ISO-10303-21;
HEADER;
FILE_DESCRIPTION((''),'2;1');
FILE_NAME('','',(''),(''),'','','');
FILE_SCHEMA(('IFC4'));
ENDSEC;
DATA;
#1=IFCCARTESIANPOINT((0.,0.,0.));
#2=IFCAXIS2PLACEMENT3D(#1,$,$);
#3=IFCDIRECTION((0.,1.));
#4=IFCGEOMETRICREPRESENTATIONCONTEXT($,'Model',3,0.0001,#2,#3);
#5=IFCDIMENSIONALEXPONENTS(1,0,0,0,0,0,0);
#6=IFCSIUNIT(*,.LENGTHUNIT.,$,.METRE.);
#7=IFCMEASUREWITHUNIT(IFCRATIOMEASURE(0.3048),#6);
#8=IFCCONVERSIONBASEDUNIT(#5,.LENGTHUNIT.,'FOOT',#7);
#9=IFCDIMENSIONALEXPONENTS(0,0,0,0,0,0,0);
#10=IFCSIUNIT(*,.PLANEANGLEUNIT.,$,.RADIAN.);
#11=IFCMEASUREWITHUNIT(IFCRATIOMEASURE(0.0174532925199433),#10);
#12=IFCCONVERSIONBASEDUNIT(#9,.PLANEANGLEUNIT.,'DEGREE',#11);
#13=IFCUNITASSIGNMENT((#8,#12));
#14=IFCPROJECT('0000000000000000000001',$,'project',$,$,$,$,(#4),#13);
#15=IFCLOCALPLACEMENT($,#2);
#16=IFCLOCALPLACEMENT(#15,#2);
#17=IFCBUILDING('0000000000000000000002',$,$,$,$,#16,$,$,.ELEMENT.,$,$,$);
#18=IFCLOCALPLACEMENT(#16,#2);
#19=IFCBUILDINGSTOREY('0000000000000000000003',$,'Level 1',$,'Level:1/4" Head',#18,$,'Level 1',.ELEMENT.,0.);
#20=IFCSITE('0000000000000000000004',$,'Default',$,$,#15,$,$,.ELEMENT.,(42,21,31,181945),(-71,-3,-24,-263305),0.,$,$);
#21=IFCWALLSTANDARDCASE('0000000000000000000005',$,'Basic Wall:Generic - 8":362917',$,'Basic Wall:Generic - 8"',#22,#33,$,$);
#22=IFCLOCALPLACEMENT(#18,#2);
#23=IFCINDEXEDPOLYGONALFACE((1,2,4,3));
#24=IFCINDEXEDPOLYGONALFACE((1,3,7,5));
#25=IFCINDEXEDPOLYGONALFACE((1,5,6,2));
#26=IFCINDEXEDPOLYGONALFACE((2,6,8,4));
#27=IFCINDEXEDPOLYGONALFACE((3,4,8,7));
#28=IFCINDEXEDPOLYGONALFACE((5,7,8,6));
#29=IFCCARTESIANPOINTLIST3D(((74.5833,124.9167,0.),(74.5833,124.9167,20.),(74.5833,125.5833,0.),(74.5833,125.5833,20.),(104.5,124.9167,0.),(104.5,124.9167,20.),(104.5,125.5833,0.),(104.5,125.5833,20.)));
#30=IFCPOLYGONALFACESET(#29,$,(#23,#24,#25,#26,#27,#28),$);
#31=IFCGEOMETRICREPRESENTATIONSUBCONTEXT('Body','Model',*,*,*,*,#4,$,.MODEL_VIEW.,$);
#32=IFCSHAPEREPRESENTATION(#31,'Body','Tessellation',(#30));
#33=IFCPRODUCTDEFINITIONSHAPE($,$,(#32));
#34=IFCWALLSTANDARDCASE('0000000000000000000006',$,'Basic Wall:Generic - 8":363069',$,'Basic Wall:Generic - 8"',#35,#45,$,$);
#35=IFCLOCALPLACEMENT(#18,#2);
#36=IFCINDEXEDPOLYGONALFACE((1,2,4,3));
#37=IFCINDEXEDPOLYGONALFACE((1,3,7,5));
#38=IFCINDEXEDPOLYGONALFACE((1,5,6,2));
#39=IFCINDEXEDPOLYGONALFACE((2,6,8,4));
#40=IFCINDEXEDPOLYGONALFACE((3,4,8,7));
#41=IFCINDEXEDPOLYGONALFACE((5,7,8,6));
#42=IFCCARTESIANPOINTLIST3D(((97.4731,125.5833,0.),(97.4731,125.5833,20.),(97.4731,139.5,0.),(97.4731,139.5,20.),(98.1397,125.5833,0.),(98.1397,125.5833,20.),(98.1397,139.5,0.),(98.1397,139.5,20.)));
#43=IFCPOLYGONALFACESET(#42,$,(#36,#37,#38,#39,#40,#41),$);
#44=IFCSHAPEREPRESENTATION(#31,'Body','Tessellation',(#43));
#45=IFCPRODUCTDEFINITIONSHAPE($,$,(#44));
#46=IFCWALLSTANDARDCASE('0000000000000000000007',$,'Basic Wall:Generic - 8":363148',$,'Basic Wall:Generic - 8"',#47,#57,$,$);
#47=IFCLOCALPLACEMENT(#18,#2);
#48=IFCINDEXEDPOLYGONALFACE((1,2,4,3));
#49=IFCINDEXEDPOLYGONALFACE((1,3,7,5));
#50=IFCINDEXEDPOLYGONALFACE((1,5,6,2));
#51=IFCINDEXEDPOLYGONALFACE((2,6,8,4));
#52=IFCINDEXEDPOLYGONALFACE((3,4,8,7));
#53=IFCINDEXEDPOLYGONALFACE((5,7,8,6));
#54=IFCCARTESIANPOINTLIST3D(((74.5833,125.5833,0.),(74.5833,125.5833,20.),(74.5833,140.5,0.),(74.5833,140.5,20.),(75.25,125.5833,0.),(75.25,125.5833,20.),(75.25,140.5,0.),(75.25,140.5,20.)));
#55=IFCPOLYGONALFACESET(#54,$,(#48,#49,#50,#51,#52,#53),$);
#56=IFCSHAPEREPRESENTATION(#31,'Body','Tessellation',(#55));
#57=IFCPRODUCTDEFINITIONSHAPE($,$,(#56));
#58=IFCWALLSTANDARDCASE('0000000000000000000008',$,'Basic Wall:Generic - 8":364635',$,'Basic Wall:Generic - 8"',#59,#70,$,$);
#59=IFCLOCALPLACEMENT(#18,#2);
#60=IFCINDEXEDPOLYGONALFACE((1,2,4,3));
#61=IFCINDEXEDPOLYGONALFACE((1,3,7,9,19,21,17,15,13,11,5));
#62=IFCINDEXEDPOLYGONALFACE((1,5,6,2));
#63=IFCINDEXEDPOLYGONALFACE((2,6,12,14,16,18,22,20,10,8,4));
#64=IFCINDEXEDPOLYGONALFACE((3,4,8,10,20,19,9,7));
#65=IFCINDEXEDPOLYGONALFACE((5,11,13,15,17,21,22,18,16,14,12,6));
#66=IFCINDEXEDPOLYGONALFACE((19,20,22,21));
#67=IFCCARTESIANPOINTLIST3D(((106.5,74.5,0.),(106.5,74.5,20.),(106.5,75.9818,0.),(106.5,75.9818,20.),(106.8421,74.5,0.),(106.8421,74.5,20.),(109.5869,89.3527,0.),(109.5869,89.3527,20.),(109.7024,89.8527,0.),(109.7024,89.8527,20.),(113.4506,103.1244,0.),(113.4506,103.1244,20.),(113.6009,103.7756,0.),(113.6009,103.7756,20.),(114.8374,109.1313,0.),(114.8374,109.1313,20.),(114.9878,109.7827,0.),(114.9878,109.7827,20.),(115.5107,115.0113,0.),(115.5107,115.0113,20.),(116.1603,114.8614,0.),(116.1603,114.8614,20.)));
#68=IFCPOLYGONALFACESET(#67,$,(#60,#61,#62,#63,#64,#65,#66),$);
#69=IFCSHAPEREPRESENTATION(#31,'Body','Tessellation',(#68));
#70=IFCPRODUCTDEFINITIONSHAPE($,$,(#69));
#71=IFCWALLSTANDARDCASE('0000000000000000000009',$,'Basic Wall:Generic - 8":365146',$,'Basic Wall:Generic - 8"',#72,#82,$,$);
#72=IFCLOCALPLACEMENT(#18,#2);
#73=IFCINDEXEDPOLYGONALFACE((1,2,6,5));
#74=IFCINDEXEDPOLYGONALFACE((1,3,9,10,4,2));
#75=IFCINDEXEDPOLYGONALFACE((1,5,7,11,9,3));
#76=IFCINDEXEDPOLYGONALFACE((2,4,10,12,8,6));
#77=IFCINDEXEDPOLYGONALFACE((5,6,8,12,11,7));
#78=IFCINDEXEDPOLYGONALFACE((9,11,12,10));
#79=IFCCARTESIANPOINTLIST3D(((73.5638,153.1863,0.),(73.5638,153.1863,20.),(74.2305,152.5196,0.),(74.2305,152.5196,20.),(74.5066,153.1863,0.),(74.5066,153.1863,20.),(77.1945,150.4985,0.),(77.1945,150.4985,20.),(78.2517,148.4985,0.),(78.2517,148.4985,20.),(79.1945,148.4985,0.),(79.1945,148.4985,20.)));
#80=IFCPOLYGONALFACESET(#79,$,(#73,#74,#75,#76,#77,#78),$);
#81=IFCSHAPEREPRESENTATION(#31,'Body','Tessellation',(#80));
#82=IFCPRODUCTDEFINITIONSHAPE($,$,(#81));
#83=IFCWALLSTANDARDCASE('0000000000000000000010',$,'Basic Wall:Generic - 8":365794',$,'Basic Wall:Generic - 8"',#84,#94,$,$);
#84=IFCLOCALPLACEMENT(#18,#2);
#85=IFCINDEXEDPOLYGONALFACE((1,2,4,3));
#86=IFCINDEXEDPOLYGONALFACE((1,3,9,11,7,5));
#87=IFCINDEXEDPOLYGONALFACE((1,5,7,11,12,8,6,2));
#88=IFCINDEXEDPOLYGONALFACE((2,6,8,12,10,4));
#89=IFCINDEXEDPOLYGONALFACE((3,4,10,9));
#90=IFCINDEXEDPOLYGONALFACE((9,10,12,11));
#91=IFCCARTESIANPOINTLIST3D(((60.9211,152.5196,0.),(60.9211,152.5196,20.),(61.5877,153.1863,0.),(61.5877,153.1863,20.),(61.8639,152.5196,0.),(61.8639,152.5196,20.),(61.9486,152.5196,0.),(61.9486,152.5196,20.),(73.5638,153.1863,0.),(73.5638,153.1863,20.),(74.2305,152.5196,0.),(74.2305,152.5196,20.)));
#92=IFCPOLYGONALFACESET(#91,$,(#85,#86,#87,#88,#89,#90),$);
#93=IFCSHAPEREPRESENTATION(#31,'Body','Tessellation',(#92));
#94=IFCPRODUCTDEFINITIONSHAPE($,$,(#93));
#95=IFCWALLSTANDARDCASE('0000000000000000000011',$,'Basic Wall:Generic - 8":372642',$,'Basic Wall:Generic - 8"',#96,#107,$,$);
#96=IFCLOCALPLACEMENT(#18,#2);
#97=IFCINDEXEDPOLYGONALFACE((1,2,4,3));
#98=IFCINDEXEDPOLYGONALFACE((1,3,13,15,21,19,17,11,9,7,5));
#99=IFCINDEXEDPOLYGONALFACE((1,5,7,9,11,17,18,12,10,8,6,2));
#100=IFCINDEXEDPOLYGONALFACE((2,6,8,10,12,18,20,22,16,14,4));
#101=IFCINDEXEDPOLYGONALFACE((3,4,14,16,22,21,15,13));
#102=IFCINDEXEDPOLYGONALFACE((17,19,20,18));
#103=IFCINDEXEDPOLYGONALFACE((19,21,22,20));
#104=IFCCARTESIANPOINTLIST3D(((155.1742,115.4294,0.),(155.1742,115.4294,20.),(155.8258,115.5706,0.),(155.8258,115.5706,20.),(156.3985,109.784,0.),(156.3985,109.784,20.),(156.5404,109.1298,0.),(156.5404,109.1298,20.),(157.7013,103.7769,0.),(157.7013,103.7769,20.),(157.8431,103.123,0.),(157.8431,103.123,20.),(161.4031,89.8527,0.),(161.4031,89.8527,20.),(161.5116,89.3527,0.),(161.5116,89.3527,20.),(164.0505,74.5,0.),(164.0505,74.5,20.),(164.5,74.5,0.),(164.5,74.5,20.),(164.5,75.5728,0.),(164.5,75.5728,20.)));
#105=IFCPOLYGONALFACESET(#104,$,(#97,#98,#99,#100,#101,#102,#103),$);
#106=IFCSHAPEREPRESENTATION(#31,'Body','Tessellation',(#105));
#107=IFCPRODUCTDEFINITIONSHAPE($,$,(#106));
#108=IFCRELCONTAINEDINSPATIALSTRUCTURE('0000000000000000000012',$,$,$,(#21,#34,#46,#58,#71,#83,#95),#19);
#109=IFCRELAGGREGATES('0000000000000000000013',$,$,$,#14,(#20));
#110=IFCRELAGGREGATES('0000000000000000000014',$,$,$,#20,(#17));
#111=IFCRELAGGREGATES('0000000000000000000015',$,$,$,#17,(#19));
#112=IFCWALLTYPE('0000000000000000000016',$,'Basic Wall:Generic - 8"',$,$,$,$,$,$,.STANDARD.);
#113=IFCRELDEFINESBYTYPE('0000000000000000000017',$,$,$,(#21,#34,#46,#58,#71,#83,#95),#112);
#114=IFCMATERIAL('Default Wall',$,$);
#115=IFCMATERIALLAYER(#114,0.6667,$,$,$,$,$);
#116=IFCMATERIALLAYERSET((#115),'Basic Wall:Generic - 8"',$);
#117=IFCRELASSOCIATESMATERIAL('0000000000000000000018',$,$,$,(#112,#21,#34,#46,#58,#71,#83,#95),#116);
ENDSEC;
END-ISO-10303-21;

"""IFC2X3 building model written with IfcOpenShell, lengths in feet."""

from ifc_helpers import new_model, entity, si_unit, converted_unit, direction, frame, frame_2d, origin, place, context, subcontext, project, spatial, polyline, rectangle, outline, extrude, material, layer, layer_set, layer_usage, type_object, element, save


model = new_model("IFC2X3")

# Units and contexts
model_context = context("Model", 3, precision=0.0001, world=origin(), true_north=direction((0.0, 1.0)))
body_context = subcontext(model_context, "Body", "Model", "MODEL_VIEW")
ifc_project = project(units=[converted_unit("LENGTHUNIT", "FOOT", entity("IfcRatioMeasure", 0.3048), si_unit("LENGTHUNIT", "METRE"), dimensions=[1, 0, 0, 0, 0, 0, 0]), converted_unit("PLANEANGLEUNIT", "DEGREE", entity("IfcRatioMeasure", 0.0174532925199433), si_unit("PLANEANGLEUNIT", "RADIAN"), dimensions=[0, 0, 0, 0, 0, 0, 0])], contexts=[model_context])

# Site, building, storey
site_placement = place(None, origin())
site = spatial("IfcSite", under=ifc_project, at=site_placement, Name="Default", CompositionType="ELEMENT", RefLatitude=(42, 21, 31, 181945), RefLongitude=(-71, -3, -24, -263305), RefElevation=0.0)
building_placement = place(site_placement, origin())
building = spatial("IfcBuilding", under=site, at=building_placement, CompositionType="ELEMENT")
storey_placement = place(building_placement, origin())
storey = spatial("IfcBuildingStorey", under=building, at=storey_placement, Name="Level 1", ObjectType="Level:1/4\" Head", LongName="Level 1", CompositionType="ELEMENT", Elevation=0.0)

# Walls
ifc_material = material(Name="Default Wall")
ifc_layer_1 = layer(ifc_material, 0.6667)
ifc_layer_set_1 = layer_set([ifc_layer_1], Name="Basic Wall:Generic - 8\"")
ifc_layer_usage_1 = layer_usage(ifc_layer_set_1, "AXIS2", "NEGATIVE", 0.3333)
wall_type_1 = type_object("IfcWallType", Name="Basic Wall:Generic - 8\"", PredefinedType="STANDARD", material=ifc_layer_set_1)
wall_1_placement = place(storey_placement, frame((74.5833, 125.25, 0.0)))
element("IfcWallStandardCase", 1, at=wall_1_placement, inside=storey, type_object=wall_type_1, material=ifc_layer_usage_1, Name="Basic Wall:Generic - 8\":362917", ObjectType="Basic Wall:Generic - 8\"", context=body_context, shape_type="SweptSolid", body=[
    extrude(rectangle(XDim=29.9167, YDim=0.6667, at=frame_2d((14.9583, 0.0), x_axis=(-1.0, 0.0))), origin(), (0.0, 0.0, 1.0), 20.0),
])
ifc_layer_usage_2 = layer_usage(ifc_layer_set_1, "AXIS2", "NEGATIVE", 0.3333)
wall_2_placement = place(storey_placement, frame((97.8064, 139.5, 0.0), z_axis=(0.0, 0.0, 1.0), x_axis=(0.0, -1.0, 0.0)))
element("IfcWallStandardCase", 2, at=wall_2_placement, inside=storey, type_object=wall_type_1, material=ifc_layer_usage_2, Name="Basic Wall:Generic - 8\":363069", ObjectType="Basic Wall:Generic - 8\"", context=body_context, shape_type="SweptSolid", body=[
    extrude(rectangle(XDim=13.9167, YDim=0.6667, at=frame_2d((6.9583, 0.0), x_axis=(-1.0, 0.0))), origin(), (0.0, 0.0, 1.0), 20.0),
])
ifc_layer_usage_3 = layer_usage(ifc_layer_set_1, "AXIS2", "NEGATIVE", 0.3333)
wall_3_placement = place(storey_placement, frame((74.9167, 140.5, 0.0), z_axis=(0.0, 0.0, 1.0), x_axis=(0.0, -1.0, 0.0)))
element("IfcWallStandardCase", 3, at=wall_3_placement, inside=storey, type_object=wall_type_1, material=ifc_layer_usage_3, Name="Basic Wall:Generic - 8\":363148", ObjectType="Basic Wall:Generic - 8\"", context=body_context, shape_type="SweptSolid", body=[
    extrude(rectangle(XDim=14.9167, YDim=0.6667, at=frame_2d((7.4583, 0.0), x_axis=(-1.0, 0.0))), origin(), (0.0, 0.0, 1.0), 20.0),
])
ifc_layer_usage_4 = layer_usage(ifc_layer_set_1, "AXIS2", "NEGATIVE", 0.3333)
wall_4_placement = place(storey_placement, frame((106.5173, 74.575, 0.0), z_axis=(0.0, 0.0, 1.0), x_axis=(0.224951, 0.97437, 0.0)))
element("IfcWallStandardCase", 4, at=wall_4_placement, inside=storey, type_object=wall_type_1, material=ifc_layer_usage_4, Name="Basic Wall:Generic - 8\":364635", ObjectType="Basic Wall:Generic - 8\"", context=body_context, shape_type="SweptSolid", body=[
    extrude(outline(polyline([(41.423, -0.3333), (41.423, 0.3333), (15.6027, 0.3333), (15.0895, 0.3333), (1.3669, 0.3333), (-0.077, 0.0), (0.0, -0.3333), (29.3773, -0.3333), (30.0457, -0.3333), (35.5422, -0.3333), (36.2108, -0.3333), (41.423, -0.3333)])), origin(), (0.0, 0.0, 1.0), 20.0),
])
ifc_layer_usage_5 = layer_usage(ifc_layer_set_1, "AXIS2", "NEGATIVE", 0.3333)
wall_5_placement = place(storey_placement, frame((78.9588, 148.2628, 0.0), z_axis=(0.0, 0.0, 1.0), x_axis=(-0.707107, 0.707107, 0.0)))
element("IfcWallStandardCase", 5, at=wall_5_placement, inside=storey, type_object=wall_type_1, material=ifc_layer_usage_5, Name="Basic Wall:Generic - 8\":365146", ObjectType="Basic Wall:Generic - 8\"", context=body_context, shape_type="SweptSolid", body=[
    extrude(outline(polyline([(6.6296, -0.3333), (7.2963, 0.3333), (6.3534, 0.3333), (0.6667, 0.3333), (0.0, -0.3333), (2.8284, -0.3333), (6.6296, -0.3333)])), origin(), (0.0, 0.0, 1.0), 20.0),
])
ifc_layer_usage_6 = layer_usage(ifc_layer_set_1, "AXIS2", "NEGATIVE", 0.3333)
wall_6_placement = place(storey_placement, frame((74.2305, 152.8529, 0.0), z_axis=(0.0, 0.0, 1.0), x_axis=(-1.0, 0.0, 0.0)))
element("IfcWallStandardCase", 6, at=wall_6_placement, inside=storey, type_object=wall_type_1, material=ifc_layer_usage_6, Name="Basic Wall:Generic - 8\":365794", ObjectType="Basic Wall:Generic - 8\"", context=body_context, shape_type="SweptSolid", body=[
    extrude(outline(polyline([(12.6428, -0.3333), (13.3094, 0.3333), (12.3666, 0.3333), (12.2819, 0.3333), (0.0, 0.3333), (0.6667, -0.3333), (12.6428, -0.3333)])), origin(), (0.0, 0.0, 1.0), 20.0),
])
ifc_layer_usage_7 = layer_usage(ifc_layer_set_1, "AXIS2", "NEGATIVE", 0.3333)
wall_7_placement = place(storey_placement, frame((155.5, 115.5, 0.0), z_axis=(0.0, 0.0, 1.0), x_axis=(0.211941, -0.977283, 0.0)))
element("IfcWallStandardCase", 7, at=wall_7_placement, inside=storey, type_object=wall_type_1, material=ifc_layer_usage_7, Name="Basic Wall:Generic - 8\":372642", ObjectType="Basic Wall:Generic - 8\"", context=body_context, shape_type="SweptSolid", body=[
    extrude(outline(polyline([(41.8808, -0.3333), (41.976, 0.106), (40.9277, 0.3333), (26.8274, 0.3333), (26.3157, 0.3333), (0.0, 0.3333), (0.0, -0.3333), (5.7766, -0.3333), (6.446, -0.3333), (11.9234, -0.3333), (12.5924, -0.3333), (41.8808, -0.3333)])), origin(), (0.0, 0.0, 1.0), 20.0),
])

save(model, "model.ifc")
